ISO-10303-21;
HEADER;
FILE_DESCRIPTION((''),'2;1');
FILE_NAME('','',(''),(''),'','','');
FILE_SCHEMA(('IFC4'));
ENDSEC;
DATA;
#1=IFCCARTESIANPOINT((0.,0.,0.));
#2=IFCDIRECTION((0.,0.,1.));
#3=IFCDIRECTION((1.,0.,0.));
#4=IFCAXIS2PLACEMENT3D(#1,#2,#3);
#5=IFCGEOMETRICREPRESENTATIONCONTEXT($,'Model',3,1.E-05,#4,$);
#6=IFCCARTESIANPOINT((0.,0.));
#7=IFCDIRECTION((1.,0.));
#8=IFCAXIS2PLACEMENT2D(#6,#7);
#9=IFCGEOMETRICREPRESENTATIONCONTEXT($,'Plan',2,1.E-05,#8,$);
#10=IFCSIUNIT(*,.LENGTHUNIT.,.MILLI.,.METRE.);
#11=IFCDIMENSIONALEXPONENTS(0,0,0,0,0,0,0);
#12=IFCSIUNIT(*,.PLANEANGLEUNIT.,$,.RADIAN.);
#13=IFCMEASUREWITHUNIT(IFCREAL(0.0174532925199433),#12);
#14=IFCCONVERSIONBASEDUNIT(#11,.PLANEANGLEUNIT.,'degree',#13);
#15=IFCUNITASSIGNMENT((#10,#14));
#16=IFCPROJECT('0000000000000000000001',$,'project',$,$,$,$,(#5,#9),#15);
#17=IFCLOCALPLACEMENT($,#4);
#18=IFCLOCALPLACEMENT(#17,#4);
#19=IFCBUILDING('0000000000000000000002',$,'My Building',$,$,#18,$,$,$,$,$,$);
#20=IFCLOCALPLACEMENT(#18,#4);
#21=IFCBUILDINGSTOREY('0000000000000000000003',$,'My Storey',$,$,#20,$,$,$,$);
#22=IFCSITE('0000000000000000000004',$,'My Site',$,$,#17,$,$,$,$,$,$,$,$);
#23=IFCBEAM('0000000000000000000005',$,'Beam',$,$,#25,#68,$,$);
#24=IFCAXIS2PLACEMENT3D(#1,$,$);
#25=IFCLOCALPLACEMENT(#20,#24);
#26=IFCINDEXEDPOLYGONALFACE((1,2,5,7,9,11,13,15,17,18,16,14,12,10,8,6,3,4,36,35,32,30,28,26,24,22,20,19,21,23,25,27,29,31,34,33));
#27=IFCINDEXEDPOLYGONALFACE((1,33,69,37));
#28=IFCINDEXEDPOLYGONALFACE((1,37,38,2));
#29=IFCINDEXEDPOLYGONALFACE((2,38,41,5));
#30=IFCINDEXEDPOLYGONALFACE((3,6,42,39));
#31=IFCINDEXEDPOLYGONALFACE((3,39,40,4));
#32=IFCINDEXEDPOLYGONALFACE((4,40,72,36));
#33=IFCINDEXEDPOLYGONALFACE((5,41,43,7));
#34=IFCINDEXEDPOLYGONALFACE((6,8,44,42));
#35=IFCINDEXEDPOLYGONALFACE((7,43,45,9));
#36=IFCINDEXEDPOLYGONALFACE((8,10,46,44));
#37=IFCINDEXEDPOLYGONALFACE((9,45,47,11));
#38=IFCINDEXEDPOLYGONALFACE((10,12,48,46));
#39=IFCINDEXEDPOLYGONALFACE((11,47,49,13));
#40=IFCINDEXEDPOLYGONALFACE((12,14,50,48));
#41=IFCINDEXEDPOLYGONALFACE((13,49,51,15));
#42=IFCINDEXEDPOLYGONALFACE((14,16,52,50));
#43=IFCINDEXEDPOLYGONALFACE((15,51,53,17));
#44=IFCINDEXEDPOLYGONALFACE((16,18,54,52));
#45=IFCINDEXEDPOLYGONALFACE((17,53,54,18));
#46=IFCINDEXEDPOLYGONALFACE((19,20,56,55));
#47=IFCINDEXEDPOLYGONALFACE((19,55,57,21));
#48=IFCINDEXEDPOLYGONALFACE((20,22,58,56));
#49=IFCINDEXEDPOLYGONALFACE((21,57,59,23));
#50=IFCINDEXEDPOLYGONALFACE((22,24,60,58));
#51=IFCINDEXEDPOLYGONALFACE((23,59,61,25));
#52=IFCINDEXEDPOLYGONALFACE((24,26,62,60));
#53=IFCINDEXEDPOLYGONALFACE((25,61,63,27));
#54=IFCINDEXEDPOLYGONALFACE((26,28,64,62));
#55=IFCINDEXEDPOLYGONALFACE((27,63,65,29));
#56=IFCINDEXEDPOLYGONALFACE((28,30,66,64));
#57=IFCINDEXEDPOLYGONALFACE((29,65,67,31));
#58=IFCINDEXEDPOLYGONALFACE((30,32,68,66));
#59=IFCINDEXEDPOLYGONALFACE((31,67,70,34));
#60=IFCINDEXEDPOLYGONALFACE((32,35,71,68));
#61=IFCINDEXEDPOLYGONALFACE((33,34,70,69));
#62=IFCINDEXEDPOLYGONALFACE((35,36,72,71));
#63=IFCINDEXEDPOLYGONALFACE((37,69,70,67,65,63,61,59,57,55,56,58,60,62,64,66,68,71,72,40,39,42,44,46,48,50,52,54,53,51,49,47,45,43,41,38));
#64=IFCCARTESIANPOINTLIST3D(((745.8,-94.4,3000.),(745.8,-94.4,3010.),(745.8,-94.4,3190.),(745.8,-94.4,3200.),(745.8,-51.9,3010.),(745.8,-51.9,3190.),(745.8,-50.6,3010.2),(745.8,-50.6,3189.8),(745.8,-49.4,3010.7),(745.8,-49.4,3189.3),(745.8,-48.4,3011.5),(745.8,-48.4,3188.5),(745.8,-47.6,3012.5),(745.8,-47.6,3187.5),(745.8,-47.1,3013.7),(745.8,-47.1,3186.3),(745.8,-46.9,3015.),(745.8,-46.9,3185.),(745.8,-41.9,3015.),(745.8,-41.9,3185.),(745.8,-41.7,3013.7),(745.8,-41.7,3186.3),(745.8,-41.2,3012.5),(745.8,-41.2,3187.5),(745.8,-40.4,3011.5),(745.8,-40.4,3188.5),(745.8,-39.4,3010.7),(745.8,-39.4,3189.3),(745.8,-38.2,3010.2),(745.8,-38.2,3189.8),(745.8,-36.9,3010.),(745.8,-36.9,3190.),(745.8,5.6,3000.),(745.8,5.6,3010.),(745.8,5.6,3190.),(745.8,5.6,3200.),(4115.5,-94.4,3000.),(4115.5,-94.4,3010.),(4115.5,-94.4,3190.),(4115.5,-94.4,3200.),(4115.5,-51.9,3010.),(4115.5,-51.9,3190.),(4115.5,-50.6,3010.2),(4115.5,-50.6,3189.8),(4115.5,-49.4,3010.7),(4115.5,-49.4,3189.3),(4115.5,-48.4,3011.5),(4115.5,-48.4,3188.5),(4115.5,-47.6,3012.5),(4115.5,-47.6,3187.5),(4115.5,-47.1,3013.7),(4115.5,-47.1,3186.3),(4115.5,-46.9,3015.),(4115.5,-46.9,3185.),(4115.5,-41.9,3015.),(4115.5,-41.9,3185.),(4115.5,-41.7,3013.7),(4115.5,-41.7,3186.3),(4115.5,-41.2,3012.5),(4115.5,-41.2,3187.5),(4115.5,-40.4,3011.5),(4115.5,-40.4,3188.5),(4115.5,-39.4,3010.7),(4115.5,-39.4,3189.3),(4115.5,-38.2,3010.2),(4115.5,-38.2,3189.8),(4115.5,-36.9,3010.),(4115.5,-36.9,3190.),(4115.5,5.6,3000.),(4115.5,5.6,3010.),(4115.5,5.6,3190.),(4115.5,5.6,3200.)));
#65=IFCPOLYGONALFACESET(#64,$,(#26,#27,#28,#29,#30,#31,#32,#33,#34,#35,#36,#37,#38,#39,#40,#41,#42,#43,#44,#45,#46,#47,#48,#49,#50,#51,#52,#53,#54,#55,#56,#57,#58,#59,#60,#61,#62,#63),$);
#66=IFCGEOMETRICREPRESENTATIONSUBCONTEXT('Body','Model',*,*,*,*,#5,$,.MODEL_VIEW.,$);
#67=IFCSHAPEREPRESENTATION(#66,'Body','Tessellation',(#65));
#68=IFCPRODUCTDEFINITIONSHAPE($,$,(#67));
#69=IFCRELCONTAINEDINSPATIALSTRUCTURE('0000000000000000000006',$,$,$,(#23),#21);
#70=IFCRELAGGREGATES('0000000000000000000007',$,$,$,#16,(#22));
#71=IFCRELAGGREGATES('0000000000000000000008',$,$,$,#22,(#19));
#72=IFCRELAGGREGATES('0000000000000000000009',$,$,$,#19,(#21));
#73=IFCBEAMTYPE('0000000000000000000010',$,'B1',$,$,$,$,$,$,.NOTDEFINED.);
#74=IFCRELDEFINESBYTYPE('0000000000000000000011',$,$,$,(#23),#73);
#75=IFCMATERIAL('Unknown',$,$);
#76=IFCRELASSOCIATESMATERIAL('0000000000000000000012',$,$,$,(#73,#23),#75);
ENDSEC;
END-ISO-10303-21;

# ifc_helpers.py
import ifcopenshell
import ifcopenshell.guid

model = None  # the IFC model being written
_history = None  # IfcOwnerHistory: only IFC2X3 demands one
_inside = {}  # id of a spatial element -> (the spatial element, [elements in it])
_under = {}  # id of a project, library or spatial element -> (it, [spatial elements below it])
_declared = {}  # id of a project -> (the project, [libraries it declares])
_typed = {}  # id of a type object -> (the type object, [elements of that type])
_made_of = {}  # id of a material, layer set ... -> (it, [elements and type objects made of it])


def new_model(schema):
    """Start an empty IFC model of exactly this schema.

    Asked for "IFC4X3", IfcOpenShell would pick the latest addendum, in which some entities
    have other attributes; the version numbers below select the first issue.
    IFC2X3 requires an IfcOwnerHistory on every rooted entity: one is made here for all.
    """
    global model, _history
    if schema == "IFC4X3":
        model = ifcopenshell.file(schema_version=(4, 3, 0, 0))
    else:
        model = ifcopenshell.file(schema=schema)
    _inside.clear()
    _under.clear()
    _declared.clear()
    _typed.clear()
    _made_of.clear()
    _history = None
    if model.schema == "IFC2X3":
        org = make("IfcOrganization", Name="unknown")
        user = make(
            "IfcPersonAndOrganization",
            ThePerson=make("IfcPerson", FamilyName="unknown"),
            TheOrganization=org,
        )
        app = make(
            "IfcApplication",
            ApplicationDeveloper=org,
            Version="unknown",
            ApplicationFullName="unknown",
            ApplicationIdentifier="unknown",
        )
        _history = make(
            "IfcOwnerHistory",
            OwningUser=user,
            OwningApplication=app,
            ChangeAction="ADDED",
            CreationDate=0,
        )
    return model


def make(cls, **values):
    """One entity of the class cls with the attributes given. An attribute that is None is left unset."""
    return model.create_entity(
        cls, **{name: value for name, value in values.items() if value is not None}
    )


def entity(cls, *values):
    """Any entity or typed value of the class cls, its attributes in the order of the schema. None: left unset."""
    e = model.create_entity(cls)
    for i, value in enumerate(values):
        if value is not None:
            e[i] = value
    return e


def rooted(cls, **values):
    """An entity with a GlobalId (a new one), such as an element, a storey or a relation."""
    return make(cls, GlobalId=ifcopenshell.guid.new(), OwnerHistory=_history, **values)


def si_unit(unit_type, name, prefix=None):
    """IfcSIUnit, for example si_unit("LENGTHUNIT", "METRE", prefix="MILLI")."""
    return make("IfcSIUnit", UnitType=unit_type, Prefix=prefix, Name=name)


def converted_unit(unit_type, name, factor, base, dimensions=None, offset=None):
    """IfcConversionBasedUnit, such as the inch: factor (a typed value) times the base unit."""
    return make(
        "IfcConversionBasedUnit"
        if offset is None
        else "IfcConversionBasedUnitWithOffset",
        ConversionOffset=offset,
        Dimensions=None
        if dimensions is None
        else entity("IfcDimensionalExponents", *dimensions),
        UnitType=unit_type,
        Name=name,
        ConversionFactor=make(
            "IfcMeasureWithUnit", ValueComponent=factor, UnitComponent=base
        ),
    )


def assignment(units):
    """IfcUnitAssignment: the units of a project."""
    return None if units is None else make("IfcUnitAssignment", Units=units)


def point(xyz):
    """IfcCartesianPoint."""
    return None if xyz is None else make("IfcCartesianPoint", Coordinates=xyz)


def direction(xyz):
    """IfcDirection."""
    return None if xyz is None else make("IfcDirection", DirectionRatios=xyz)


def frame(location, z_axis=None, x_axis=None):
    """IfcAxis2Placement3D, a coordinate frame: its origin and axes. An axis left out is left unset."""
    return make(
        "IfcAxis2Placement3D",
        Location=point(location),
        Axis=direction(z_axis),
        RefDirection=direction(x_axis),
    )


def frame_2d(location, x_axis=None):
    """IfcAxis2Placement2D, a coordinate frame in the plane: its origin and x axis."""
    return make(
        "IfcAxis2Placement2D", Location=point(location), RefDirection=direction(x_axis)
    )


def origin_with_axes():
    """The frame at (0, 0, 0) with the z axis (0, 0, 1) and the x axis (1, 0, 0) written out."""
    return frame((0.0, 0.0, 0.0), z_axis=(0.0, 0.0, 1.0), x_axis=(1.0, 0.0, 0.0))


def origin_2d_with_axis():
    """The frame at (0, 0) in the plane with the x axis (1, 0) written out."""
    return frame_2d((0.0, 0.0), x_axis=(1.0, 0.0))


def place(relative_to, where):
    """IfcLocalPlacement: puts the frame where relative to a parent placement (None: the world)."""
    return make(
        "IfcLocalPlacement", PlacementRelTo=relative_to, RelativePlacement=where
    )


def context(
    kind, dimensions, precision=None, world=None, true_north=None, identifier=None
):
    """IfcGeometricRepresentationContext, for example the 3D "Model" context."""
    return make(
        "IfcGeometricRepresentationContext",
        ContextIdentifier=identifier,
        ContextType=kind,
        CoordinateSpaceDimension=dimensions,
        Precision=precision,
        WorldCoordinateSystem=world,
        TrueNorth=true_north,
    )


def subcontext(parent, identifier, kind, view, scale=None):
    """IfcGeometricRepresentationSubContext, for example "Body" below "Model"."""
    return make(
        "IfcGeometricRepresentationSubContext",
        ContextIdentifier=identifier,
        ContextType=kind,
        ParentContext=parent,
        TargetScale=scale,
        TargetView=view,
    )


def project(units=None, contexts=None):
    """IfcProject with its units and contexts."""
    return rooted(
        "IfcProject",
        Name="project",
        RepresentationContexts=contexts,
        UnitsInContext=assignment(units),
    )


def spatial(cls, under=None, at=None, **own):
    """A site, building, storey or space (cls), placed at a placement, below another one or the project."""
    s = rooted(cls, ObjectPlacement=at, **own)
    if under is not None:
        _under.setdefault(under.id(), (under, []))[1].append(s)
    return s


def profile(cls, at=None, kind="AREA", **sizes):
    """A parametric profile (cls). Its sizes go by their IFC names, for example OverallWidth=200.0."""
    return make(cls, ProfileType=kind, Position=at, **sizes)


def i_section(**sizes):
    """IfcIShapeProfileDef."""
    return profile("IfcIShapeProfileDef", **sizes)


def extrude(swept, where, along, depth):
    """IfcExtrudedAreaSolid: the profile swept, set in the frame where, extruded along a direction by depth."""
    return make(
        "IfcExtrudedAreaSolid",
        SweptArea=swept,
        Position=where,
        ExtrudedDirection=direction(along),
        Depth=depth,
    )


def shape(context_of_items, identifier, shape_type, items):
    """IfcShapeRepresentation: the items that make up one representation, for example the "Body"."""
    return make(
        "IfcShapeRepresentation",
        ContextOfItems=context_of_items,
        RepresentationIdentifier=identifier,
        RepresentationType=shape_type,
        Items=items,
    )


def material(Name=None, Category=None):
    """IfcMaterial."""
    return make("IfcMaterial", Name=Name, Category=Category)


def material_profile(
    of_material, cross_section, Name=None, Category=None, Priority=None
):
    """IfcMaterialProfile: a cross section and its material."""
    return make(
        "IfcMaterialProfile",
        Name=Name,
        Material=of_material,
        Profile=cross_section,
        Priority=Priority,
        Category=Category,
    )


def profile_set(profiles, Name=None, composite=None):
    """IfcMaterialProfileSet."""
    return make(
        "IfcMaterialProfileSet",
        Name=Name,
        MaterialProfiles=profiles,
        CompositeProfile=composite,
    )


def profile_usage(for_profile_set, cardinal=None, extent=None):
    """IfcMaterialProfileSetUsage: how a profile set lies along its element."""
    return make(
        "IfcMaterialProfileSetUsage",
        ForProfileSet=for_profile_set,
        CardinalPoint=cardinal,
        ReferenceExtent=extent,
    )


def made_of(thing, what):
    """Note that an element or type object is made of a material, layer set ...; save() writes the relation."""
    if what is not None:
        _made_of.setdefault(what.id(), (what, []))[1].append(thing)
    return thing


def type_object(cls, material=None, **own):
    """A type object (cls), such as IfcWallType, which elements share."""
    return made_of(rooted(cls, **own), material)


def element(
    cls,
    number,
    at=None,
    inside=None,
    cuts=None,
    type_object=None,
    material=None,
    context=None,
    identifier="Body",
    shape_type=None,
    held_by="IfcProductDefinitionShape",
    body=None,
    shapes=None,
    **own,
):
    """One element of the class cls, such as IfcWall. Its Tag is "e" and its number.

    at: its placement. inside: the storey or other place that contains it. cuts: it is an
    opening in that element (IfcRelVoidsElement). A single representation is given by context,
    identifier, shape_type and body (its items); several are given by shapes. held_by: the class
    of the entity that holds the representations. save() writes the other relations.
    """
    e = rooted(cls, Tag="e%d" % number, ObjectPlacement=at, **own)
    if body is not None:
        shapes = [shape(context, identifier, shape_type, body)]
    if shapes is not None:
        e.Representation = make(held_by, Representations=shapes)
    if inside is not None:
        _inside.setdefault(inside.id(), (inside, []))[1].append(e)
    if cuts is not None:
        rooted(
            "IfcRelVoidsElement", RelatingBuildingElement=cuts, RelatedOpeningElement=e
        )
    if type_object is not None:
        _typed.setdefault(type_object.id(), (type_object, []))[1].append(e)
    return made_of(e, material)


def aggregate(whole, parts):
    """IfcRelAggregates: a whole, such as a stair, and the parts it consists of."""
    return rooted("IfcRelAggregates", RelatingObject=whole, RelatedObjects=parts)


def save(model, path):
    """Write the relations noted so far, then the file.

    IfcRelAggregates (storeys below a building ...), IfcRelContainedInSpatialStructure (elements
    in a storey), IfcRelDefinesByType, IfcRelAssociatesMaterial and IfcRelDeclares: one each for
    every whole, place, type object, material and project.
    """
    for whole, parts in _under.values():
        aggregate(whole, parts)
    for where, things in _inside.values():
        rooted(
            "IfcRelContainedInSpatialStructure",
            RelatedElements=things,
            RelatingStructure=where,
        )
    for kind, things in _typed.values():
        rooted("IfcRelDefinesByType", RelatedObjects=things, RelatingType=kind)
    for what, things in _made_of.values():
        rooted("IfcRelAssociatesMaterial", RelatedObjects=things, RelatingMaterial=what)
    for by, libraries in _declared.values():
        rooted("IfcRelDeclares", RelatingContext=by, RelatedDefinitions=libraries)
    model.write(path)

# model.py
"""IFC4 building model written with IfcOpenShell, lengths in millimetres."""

from ifc_helpers import new_model, entity, si_unit, converted_unit, frame, origin_with_axes, origin_2d_with_axis, place, context, subcontext, project, spatial, i_section, extrude, material, material_profile, profile_set, profile_usage, type_object, element, save


model = new_model("IFC4")

# Units and contexts
model_context = context("Model", 3, precision=1e-05, world=origin_with_axes())
plan_context = context("Plan", 2, precision=1e-05, world=origin_2d_with_axis())
body_context = subcontext(model_context, "Body", "Model", "MODEL_VIEW")
ifc_project = project(units=[si_unit("LENGTHUNIT", "METRE", prefix="MILLI"), converted_unit("PLANEANGLEUNIT", "degree", entity("IfcReal", 0.0174532925199433), si_unit("PLANEANGLEUNIT", "RADIAN"), dimensions=[0, 0, 0, 0, 0, 0, 0])], contexts=[model_context, plan_context])

# Site, building, storey
site_placement = place(None, origin_with_axes())
site = spatial("IfcSite", under=ifc_project, at=site_placement, Name="My Site")
building_placement = place(site_placement, origin_with_axes())
building = spatial("IfcBuilding", under=site, at=building_placement, Name="My Building")
storey_placement = place(building_placement, origin_with_axes())
storey = spatial("IfcBuildingStorey", under=building, at=storey_placement, Name="My Storey")

# Shared definitions
ifc_material = material(Name="Unknown")

# Beam
ifc_material_profile_1 = material_profile(ifc_material, i_section(OverallWidth=100.0, OverallDepth=200.0, WebThickness=5.0, FlangeThickness=10.0, FilletRadius=5.0))
ifc_profile_set_1 = profile_set([ifc_material_profile_1])
ifc_profile_usage_1 = profile_usage(ifc_profile_set_1, cardinal=5)
beam_type = type_object("IfcBeamType", Name="B1", PredefinedType="NOTDEFINED", material=ifc_profile_set_1)
beam_placement = place(storey_placement, frame((745.8, -44.4, 3100.0), z_axis=(1.0, 0.0, 0.0), x_axis=(0.0, 1.0, 0.0)))
element("IfcBeam", 1, at=beam_placement, inside=storey, type_object=beam_type, material=ifc_profile_usage_1, Name="Beam", context=body_context, shape_type="SweptSolid", body=[
    extrude(i_section(OverallWidth=100.0, OverallDepth=200.0, WebThickness=5.0, FlangeThickness=10.0, FilletRadius=5.0), origin_with_axes(), (0.0, 0.0, 1.0), 3369.7),
])

save(model, "model.ifc")
